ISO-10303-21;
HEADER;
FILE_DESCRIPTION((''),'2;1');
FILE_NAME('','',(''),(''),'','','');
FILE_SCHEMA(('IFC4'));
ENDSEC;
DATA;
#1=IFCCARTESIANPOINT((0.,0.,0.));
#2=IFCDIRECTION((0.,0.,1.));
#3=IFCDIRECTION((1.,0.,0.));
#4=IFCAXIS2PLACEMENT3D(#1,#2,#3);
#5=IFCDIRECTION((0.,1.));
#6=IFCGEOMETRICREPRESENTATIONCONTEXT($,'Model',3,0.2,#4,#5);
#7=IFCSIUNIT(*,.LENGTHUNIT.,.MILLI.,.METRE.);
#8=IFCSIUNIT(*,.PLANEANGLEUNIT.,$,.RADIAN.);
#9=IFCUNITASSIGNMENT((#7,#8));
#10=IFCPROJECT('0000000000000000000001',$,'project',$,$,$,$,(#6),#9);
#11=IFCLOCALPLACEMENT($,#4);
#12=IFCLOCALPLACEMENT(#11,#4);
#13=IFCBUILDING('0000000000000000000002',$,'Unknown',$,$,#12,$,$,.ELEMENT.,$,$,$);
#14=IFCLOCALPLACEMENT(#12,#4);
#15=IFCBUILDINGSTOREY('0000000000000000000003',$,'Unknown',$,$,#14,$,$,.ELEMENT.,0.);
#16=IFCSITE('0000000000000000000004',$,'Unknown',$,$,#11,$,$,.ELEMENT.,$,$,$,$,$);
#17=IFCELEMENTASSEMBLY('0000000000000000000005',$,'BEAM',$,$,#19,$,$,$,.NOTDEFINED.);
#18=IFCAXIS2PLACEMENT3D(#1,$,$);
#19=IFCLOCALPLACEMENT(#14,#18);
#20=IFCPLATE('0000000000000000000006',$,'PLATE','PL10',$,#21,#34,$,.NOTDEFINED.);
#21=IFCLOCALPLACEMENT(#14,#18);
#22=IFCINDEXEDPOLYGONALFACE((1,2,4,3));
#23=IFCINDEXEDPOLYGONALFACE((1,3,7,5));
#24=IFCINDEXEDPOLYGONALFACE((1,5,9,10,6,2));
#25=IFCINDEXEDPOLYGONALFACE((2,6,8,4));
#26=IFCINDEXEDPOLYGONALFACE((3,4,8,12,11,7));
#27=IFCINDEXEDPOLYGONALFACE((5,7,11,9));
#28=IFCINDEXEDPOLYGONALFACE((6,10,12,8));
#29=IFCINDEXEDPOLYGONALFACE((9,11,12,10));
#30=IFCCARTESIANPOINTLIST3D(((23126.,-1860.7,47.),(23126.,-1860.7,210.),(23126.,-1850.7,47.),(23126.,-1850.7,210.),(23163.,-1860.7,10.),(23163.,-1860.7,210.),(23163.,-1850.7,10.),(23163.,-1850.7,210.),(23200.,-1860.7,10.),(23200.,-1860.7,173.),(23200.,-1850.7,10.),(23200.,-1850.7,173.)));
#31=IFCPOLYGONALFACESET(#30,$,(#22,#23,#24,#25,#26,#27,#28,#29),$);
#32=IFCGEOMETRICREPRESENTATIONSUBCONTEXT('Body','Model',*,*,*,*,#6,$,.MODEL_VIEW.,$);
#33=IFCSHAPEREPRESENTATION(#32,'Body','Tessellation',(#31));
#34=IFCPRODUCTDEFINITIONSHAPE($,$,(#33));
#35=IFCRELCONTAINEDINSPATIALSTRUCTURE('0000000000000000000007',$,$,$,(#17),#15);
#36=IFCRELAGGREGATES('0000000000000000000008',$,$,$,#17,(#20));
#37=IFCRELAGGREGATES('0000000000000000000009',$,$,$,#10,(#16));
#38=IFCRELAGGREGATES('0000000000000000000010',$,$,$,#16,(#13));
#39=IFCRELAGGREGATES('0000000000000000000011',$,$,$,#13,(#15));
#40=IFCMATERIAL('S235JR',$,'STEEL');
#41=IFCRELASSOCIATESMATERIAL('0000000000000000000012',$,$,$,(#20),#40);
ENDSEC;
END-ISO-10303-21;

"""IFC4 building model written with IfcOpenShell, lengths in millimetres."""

from ifc_helpers import new_model, si_unit, direction, frame, origin_with_axes, place, context, subcontext, project, spatial, line, indexed_curve, outline, extrude, material, element, aggregate, save


model = new_model("IFC4")

# Units and contexts
model_context = context("Model", 3, precision=0.2, world=origin_with_axes(), true_north=direction((0.0, 1.0)))
body_context = subcontext(model_context, "Body", "Model", "MODEL_VIEW")
ifc_project = project(units=[si_unit("LENGTHUNIT", "METRE", prefix="MILLI"), si_unit("PLANEANGLEUNIT", "RADIAN")], contexts=[model_context])

# Site, building, storey
site_placement = place(None, origin_with_axes())
site = spatial("IfcSite", under=ifc_project, at=site_placement, Name="Unknown", CompositionType="ELEMENT")
building_placement = place(site_placement, origin_with_axes())
building = spatial("IfcBuilding", under=site, at=building_placement, Name="Unknown", CompositionType="ELEMENT")
storey_placement = place(building_placement, origin_with_axes())
storey = spatial("IfcBuildingStorey", under=building, at=storey_placement, Name="Unknown", CompositionType="ELEMENT", Elevation=0.0)

# Shared definitions
ifc_material_1 = material(Name="S235JR", Category="STEEL")

# Element assembly
assembly_1_placement = place(storey_placement, frame((23050.0, -1855.7, 2275.0), z_axis=(0.0, -1.0, 0.0), x_axis=(0.0, 0.0, -1.0)))
assembly_1 = element("IfcElementAssembly", 1, at=assembly_1_placement, inside=storey, Name="BEAM", PredefinedType="NOTDEFINED")

# Plate
plate_1_placement = place(assembly_1_placement, frame((2228.0, 76.0, 0.0), z_axis=(0.0, 0.0, 1.0), x_axis=(0.707107, 0.707107, 0.0)))
plate_1 = element("IfcPlate", 2, at=plate_1_placement, material=ifc_material_1, Name="PLATE", Description="PL10", PredefinedType="NOTDEFINED", context=body_context, shape_type="SolidModel", body=[
    extrude(outline(indexed_curve([(0.0, 0.0), (52.3, 0.0), (78.5, 26.2), (-36.8, 141.4), (-89.1, 141.4), (-115.3, 115.3)], segments=[line(1, 2, 3, 4, 5, 6, 1)])), frame((0.0, 0.0, 5.0), z_axis=(0.0, 0.0, 1.0), x_axis=(1.0, 0.0, 0.0)), (0.0, 0.0, -1.0), 10.0),
])

aggregate(assembly_1, [plate_1])

save(model, "model.ifc")
